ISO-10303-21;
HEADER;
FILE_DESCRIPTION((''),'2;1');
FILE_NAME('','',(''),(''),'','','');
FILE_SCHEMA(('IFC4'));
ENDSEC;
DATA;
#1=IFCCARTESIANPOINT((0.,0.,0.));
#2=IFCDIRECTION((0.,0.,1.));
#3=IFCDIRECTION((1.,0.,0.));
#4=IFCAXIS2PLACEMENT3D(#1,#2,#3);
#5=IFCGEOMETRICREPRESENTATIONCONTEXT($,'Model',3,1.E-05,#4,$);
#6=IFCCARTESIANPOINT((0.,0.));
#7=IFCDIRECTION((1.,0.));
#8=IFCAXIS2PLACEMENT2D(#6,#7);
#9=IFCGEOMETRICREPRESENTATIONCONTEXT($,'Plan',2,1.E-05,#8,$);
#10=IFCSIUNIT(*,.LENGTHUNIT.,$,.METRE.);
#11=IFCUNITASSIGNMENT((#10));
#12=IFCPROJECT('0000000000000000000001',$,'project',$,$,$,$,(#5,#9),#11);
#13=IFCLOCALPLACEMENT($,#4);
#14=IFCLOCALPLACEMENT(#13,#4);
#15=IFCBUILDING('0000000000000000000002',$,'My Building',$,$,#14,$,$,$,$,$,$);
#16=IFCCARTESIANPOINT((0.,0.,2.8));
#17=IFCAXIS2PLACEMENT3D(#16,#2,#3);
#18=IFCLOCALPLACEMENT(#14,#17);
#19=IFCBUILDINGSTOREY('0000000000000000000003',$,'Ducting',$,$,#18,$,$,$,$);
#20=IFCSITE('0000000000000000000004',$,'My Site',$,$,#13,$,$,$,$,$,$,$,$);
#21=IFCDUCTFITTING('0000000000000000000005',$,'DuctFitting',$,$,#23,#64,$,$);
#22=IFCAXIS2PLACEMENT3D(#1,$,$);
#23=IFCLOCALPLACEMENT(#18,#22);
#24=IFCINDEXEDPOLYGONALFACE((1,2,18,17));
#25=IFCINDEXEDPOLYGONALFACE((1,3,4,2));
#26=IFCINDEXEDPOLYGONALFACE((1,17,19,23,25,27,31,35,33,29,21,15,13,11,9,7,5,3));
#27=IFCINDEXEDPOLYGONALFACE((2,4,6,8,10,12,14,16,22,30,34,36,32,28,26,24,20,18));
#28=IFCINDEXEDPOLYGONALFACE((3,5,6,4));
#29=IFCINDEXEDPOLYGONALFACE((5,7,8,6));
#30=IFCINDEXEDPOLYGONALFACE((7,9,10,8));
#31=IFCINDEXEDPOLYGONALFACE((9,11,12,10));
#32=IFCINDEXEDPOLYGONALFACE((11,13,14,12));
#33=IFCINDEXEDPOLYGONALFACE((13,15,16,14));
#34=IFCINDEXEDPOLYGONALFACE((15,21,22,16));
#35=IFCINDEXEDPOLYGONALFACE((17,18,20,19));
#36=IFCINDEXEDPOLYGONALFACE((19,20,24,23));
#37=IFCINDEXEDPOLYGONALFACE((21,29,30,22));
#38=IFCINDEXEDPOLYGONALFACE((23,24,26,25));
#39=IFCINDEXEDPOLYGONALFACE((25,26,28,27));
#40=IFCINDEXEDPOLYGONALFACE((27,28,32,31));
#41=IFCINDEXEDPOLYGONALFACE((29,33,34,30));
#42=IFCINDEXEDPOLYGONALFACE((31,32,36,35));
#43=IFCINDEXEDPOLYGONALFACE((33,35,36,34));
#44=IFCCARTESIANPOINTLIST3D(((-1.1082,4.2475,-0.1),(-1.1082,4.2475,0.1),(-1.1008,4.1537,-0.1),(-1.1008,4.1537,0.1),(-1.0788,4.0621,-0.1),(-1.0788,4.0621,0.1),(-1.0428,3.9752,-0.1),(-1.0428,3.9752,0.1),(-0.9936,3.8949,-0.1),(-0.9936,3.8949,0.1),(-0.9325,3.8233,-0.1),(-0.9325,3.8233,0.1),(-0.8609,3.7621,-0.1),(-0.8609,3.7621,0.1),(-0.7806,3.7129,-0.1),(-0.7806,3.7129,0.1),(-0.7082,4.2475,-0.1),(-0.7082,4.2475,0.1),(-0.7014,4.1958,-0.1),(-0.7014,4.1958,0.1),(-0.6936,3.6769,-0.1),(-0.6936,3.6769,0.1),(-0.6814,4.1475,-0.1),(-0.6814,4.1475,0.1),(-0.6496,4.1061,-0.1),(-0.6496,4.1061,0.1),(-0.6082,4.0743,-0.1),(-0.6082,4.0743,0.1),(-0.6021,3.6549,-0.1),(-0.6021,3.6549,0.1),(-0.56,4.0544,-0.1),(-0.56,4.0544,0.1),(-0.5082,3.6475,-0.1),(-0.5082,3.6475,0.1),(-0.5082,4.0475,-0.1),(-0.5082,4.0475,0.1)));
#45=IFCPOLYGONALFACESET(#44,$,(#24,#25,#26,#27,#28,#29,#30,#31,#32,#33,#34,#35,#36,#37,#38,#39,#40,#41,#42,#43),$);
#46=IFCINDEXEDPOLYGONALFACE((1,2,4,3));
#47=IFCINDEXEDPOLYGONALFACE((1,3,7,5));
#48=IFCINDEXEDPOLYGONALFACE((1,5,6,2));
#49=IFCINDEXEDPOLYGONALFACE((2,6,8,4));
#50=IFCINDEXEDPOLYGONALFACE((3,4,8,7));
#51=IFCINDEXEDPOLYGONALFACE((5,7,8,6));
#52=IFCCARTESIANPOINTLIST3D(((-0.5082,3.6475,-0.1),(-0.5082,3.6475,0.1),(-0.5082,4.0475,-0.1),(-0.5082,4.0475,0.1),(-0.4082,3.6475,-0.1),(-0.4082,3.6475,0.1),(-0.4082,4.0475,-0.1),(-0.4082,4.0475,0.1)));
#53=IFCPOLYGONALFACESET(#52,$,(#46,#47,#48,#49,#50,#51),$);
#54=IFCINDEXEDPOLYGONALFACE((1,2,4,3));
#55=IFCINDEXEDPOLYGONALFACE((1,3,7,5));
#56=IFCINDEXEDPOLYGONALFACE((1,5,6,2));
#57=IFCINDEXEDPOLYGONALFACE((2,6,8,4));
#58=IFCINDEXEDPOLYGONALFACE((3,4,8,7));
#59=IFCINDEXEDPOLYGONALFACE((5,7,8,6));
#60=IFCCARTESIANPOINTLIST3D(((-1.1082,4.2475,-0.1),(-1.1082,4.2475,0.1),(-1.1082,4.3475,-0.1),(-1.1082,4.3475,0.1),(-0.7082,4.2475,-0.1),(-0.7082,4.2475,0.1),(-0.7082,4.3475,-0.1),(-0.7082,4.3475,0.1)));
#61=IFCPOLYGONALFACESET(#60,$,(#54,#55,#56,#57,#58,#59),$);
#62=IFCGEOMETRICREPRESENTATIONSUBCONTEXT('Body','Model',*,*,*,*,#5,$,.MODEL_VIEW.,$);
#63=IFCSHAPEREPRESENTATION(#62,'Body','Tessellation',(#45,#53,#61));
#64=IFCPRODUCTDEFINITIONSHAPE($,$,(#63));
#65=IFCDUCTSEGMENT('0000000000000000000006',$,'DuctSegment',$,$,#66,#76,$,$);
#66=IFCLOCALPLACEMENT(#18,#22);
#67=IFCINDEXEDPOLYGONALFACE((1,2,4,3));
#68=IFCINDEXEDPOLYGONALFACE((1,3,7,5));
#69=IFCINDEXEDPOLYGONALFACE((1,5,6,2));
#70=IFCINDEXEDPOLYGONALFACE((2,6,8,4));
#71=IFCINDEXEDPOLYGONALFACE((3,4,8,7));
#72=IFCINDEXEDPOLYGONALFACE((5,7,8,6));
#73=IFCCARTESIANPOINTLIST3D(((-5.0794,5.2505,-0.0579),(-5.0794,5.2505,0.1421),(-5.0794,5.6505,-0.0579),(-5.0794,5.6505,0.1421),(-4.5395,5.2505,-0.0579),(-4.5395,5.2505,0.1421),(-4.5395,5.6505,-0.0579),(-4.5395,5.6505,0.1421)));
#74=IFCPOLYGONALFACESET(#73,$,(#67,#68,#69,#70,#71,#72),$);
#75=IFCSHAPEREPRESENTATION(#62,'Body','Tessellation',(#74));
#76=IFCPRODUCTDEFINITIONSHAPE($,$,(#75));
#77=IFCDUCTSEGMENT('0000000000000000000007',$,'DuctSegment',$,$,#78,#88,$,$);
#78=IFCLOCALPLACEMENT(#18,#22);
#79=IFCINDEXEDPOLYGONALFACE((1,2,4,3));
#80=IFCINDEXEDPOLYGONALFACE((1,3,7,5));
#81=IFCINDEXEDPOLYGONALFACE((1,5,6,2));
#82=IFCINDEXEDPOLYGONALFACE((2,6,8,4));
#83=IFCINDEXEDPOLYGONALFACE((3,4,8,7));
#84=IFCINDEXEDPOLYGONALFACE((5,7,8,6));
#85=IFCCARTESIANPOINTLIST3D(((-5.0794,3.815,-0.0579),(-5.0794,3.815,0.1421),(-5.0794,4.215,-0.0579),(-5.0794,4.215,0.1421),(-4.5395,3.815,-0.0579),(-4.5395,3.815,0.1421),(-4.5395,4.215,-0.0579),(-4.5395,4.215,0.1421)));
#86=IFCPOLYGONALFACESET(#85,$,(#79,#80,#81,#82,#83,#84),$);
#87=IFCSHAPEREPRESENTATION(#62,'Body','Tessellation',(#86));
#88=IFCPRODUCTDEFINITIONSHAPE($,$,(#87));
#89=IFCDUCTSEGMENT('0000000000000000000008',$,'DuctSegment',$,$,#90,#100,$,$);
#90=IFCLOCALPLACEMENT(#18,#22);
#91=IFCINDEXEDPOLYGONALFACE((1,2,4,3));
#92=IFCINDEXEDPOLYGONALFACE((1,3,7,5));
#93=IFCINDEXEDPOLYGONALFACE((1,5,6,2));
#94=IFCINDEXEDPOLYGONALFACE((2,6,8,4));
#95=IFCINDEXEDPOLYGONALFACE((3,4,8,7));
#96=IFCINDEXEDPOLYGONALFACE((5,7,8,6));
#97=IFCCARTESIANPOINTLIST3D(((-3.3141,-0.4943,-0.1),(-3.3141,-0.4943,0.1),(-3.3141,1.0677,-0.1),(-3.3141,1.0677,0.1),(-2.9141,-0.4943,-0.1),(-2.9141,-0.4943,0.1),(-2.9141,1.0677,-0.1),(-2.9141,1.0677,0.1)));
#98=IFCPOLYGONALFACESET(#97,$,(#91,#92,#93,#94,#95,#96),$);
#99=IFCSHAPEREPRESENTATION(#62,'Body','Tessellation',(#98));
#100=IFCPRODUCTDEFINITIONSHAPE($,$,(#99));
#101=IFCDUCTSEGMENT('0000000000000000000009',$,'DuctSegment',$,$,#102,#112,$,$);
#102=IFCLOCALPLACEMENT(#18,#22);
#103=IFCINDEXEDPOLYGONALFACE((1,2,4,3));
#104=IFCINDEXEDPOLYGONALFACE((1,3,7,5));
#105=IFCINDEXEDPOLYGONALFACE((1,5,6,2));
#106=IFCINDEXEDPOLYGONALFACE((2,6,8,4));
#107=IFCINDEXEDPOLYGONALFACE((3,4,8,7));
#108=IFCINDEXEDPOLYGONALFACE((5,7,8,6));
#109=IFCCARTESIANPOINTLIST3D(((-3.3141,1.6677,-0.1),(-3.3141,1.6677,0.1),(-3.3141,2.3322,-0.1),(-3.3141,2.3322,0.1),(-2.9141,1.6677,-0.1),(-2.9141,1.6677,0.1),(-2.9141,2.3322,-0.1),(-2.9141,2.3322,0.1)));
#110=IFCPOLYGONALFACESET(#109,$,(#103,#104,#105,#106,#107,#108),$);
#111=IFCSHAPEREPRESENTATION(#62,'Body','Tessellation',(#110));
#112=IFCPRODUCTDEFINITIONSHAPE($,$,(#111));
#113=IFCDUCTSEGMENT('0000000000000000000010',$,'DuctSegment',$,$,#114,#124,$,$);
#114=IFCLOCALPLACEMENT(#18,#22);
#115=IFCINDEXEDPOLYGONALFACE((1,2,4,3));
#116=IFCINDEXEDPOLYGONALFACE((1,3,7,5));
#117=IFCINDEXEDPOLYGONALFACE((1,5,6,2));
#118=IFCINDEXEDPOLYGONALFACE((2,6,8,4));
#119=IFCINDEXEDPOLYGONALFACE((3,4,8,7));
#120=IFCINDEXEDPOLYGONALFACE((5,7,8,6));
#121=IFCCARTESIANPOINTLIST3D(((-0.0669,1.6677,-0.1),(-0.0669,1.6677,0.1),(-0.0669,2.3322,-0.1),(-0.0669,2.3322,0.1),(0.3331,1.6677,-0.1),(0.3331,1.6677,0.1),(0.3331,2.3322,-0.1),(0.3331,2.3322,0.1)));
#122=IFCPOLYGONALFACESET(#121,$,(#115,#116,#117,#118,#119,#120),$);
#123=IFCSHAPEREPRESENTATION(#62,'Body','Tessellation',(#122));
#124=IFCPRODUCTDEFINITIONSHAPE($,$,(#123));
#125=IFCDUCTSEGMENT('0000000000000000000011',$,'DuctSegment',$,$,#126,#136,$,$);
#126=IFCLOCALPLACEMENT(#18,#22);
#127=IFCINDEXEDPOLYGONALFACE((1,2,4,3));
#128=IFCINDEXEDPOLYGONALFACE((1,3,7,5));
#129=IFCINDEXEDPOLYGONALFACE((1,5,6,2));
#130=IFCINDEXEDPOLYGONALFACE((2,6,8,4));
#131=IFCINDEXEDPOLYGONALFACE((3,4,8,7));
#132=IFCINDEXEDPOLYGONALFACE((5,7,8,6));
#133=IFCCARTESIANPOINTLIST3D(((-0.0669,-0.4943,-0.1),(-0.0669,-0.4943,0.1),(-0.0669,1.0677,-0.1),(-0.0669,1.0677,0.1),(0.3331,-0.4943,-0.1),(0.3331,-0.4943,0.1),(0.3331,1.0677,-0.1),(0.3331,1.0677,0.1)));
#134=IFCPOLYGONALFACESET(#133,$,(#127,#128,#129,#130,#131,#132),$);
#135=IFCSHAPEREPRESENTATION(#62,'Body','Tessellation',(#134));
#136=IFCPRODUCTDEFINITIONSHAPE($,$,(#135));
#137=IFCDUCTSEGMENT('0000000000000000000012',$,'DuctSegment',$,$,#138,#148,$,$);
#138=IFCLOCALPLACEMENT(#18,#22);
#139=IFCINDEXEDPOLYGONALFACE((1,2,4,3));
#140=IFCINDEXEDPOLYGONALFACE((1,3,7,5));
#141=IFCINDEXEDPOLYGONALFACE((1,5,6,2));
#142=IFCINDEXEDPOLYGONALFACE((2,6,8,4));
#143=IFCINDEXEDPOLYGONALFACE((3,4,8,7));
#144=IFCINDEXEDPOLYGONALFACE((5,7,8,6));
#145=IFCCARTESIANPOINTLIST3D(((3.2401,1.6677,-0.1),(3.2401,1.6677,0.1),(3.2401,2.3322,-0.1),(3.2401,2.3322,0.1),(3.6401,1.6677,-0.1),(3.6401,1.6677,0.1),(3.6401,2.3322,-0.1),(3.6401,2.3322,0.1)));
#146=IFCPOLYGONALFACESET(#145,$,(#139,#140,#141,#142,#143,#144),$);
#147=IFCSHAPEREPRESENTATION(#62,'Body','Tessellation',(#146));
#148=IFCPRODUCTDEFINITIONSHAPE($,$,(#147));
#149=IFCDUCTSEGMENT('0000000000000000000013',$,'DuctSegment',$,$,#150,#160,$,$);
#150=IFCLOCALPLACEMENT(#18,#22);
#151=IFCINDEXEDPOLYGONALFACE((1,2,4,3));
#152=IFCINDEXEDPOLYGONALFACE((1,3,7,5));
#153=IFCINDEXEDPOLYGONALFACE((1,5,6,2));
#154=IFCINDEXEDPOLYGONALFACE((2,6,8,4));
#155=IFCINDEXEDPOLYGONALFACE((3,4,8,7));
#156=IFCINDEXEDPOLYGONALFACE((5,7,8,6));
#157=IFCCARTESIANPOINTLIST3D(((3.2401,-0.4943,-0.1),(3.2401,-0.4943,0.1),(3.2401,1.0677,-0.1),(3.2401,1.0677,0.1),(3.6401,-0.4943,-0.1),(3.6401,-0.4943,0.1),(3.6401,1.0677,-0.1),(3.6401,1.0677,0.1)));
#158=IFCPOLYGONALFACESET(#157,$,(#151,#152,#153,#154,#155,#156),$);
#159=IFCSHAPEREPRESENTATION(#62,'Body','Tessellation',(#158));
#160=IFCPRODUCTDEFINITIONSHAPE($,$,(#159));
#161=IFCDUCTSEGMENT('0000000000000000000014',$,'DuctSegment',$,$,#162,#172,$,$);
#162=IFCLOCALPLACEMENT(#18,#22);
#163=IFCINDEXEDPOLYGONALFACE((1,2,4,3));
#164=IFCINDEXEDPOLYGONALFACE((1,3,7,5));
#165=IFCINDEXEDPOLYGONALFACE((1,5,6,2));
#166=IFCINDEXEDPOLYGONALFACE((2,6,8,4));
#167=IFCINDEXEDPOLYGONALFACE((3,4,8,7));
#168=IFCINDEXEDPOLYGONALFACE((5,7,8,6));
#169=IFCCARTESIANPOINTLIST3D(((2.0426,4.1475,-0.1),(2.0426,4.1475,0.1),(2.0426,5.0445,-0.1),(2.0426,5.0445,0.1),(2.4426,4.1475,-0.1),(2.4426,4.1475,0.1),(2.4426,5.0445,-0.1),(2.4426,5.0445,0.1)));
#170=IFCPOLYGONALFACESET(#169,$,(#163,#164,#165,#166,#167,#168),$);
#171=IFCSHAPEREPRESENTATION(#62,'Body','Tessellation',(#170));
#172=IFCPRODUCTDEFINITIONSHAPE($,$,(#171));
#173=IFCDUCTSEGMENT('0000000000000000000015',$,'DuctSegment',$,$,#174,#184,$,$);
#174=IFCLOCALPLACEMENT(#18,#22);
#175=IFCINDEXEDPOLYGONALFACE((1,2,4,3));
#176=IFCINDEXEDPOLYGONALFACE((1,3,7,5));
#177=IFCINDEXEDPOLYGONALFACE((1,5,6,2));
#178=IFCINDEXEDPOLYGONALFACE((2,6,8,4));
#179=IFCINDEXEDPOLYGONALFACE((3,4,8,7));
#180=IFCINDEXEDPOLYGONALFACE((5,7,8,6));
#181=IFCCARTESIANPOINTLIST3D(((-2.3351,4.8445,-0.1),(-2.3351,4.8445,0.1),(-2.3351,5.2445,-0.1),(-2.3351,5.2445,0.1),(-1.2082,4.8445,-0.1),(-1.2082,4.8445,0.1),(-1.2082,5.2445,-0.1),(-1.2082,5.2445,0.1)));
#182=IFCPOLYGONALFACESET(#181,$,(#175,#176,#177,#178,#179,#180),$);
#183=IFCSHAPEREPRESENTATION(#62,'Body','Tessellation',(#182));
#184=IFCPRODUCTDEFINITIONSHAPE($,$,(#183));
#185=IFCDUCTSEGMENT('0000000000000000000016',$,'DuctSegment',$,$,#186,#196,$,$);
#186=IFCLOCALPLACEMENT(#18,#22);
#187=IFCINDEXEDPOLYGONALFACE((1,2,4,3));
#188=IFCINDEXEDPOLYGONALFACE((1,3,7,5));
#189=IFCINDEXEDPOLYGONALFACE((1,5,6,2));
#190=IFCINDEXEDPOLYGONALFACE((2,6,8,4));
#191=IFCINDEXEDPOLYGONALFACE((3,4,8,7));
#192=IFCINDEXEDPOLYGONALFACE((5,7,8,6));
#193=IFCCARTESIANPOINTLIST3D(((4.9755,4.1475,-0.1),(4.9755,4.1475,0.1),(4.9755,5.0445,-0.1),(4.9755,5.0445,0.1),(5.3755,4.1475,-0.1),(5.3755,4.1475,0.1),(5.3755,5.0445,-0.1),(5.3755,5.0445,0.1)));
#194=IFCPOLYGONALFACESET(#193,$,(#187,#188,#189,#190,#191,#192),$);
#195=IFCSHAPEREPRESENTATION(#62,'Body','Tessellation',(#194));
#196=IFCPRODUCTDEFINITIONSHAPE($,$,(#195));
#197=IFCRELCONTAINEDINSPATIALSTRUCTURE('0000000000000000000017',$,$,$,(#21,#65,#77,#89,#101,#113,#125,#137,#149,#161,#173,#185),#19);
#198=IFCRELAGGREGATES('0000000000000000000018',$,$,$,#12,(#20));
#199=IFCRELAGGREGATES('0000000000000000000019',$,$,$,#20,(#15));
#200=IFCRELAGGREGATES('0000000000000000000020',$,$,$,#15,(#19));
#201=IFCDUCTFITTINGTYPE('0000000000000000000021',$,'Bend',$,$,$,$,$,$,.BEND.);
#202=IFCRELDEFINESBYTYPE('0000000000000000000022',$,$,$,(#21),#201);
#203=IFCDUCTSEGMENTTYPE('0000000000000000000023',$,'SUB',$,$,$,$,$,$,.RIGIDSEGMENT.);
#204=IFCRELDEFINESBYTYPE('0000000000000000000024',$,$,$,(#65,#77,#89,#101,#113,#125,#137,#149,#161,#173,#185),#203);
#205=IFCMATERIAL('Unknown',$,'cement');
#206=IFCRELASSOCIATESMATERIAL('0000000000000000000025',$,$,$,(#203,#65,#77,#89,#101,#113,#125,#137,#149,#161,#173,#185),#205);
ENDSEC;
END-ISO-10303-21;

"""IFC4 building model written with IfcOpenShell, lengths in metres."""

from ifc_helpers import new_model, si_unit, frame, origin_with_axes, origin_2d_with_axis, place, context, subcontext, project, spatial, line, arc, indexed_curve, rectangle, outline, extrude, source, transform, mapped, material, material_profile, profile_set, profile_usage, type_object, type_shapes, element, save


model = new_model("IFC4")

# Units and contexts
model_context = context("Model", 3, precision=1e-05, world=origin_with_axes())
plan_context = context("Plan", 2, precision=1e-05, world=origin_2d_with_axis())
body_context = subcontext(model_context, "Body", "Model", "MODEL_VIEW")
ifc_project = project(units=[si_unit("LENGTHUNIT", "METRE")], contexts=[model_context, plan_context])

# Site, building, storey
site_placement = place(None, origin_with_axes())
site = spatial("IfcSite", under=ifc_project, at=site_placement, Name="My Site")
building_placement = place(site_placement, origin_with_axes())
building = spatial("IfcBuilding", under=site, at=building_placement, Name="My Building")
storey_placement = place(building_placement, frame((0.0, 0.0, 2.8), z_axis=(0.0, 0.0, 1.0), x_axis=(1.0, 0.0, 0.0)))
storey = spatial("IfcBuildingStorey", under=building, at=storey_placement, Name="Ducting")

# Shared definitions
ifc_material = material(Name="Unknown", Category="cement")

# Duct fitting
duct_fitting_type_1 = type_object("IfcDuctFittingType", Name="Bend", PredefinedType="BEND")
shared_shape = source(origin_with_axes(), body_context, "Body", "SweptSolid", [
    extrude(outline(indexed_curve([(0.2, 0.0), (0.2586, 0.1414), (0.4, 0.2), (0.4, 0.6), (-0.0243, 0.4243), (-0.2, 0.0)], segments=[arc(1, 2, 3), line(3, 4), arc(4, 5, 6), line(6, 1)])), frame((0.0, -0.1, 0.1), z_axis=(0.0, -1.0, 0.0), x_axis=(1.0, 0.0, 0.0)), (0.0, 0.0, -1.0), 0.2),
    extrude(rectangle(XDim=0.4, YDim=0.2), origin_with_axes(), (0.0, 0.0, 1.0), 0.1),
    extrude(rectangle(XDim=0.4, YDim=0.2), frame((0.4, 0.0, 0.5), z_axis=(1.0, 0.0, 0.000001), x_axis=(-0.000001, 0.0, 1.0)), (0.0, 0.0, 1.0), 0.1),
])
type_shapes(duct_fitting_type_1, [shared_shape])
for number, where, z_axis, x_axis, name in (
    (1, (-0.4082, 3.8475, 0.0), (-1.0, 0.0, 0.0), (0.0, 1.0, 0.0), "DuctFitting"),
):
    element("IfcDuctFitting", number, at=place(storey_placement, frame(where, z_axis=z_axis, x_axis=x_axis)), inside=storey, type_object=duct_fitting_type_1, Name=name, context=body_context, shape_type="MappedRepresentation", body=[
        mapped(shared_shape, transform((0.0, 0.0, 0.0), x_axis=(1.0, 0.0, 0.0), y_axis=(0.0, 1.0, 0.0), z_axis=(0.0, 0.0, 1.0), scale=1.0)),
    ])

# Duct segments
ifc_material_profile_1 = material_profile(ifc_material, rectangle(XDim=0.4, YDim=0.2))
ifc_profile_set_1 = profile_set([ifc_material_profile_1])
ifc_profile_usage_1 = profile_usage(ifc_profile_set_1, cardinal=5)
duct_segment_type_1 = type_object("IfcDuctSegmentType", Name="SUB", PredefinedType="RIGIDSEGMENT", material=ifc_profile_set_1)
duct_segment_1_placement = place(storey_placement, frame((-4.5395, 5.4505, 0.0421), z_axis=(-1.0, 0.0, 0.0), x_axis=(0.0, -1.0, 0.0)))
element("IfcDuctSegment", 2, at=duct_segment_1_placement, inside=storey, type_object=duct_segment_type_1, material=ifc_profile_usage_1, Name="DuctSegment", context=body_context, shape_type="SweptSolid", body=[
    extrude(rectangle(XDim=0.4, YDim=0.2), origin_with_axes(), (0.0, 0.0, 1.0), 0.5399),
])
ifc_profile_usage_2 = profile_usage(ifc_profile_set_1, cardinal=5)
duct_segment_2_placement = place(storey_placement, frame((-4.5395, 4.015, 0.0421), z_axis=(-1.0, 0.0, 0.0), x_axis=(0.0, -1.0, 0.0)))
element("IfcDuctSegment", 3, at=duct_segment_2_placement, inside=storey, type_object=duct_segment_type_1, material=ifc_profile_usage_2, Name="DuctSegment", context=body_context, shape_type="SweptSolid", body=[
    extrude(rectangle(XDim=0.4, YDim=0.2), origin_with_axes(), (0.0, 0.0, 1.0), 0.5399),
])
ifc_profile_usage_3 = profile_usage(ifc_profile_set_1, cardinal=5)
duct_segment_3_placement = place(storey_placement, frame((-3.1141, -0.4943, 0.0), z_axis=(0.0, 1.0, 0.0), x_axis=(-1.0, 0.0, 0.0)))
element("IfcDuctSegment", 4, at=duct_segment_3_placement, inside=storey, type_object=duct_segment_type_1, material=ifc_profile_usage_3, Name="DuctSegment", context=body_context, shape_type="SweptSolid", body=[
    extrude(rectangle(XDim=0.4, YDim=0.2), origin_with_axes(), (0.0, 0.0, 1.0), 1.5621),
])
ifc_profile_usage_4 = profile_usage(ifc_profile_set_1, cardinal=5)
duct_segment_4_placement = place(storey_placement, frame((-3.1141, 2.3322, 0.0), z_axis=(0.0, -1.0, 0.0), x_axis=(1.0, 0.0, 0.0)))
element("IfcDuctSegment", 5, at=duct_segment_4_placement, inside=storey, type_object=duct_segment_type_1, material=ifc_profile_usage_4, Name="DuctSegment", context=body_context, shape_type="SweptSolid", body=[
    extrude(rectangle(XDim=0.4, YDim=0.2), origin_with_axes(), (0.0, 0.0, 1.0), 0.6645),
])
ifc_profile_usage_5 = profile_usage(ifc_profile_set_1, cardinal=5)
duct_segment_5_placement = place(storey_placement, frame((0.1331, 2.3322, 0.0), z_axis=(0.0, -1.0, 0.0), x_axis=(1.0, 0.0, 0.0)))
element("IfcDuctSegment", 6, at=duct_segment_5_placement, inside=storey, type_object=duct_segment_type_1, material=ifc_profile_usage_5, Name="DuctSegment", context=body_context, shape_type="SweptSolid", body=[
    extrude(rectangle(XDim=0.4, YDim=0.2), origin_with_axes(), (0.0, 0.0, 1.0), 0.6645),
])
ifc_profile_usage_6 = profile_usage(ifc_profile_set_1, cardinal=5)
duct_segment_6_placement = place(storey_placement, frame((0.1331, -0.4943, 0.0), z_axis=(0.0, 1.0, 0.0), x_axis=(-1.0, 0.0, 0.0)))
element("IfcDuctSegment", 7, at=duct_segment_6_placement, inside=storey, type_object=duct_segment_type_1, material=ifc_profile_usage_6, Name="DuctSegment", context=body_context, shape_type="SweptSolid", body=[
    extrude(rectangle(XDim=0.4, YDim=0.2), origin_with_axes(), (0.0, 0.0, 1.0), 1.5621),
])
ifc_profile_usage_7 = profile_usage(ifc_profile_set_1, cardinal=5)
duct_segment_7_placement = place(storey_placement, frame((3.4401, 2.3322, 0.0), z_axis=(0.0, -1.0, 0.0), x_axis=(1.0, 0.0, 0.0)))
element("IfcDuctSegment", 8, at=duct_segment_7_placement, inside=storey, type_object=duct_segment_type_1, material=ifc_profile_usage_7, Name="DuctSegment", context=body_context, shape_type="SweptSolid", body=[
    extrude(rectangle(XDim=0.4, YDim=0.2), origin_with_axes(), (0.0, 0.0, 1.0), 0.6645),
])
ifc_profile_usage_8 = profile_usage(ifc_profile_set_1, cardinal=5)
duct_segment_8_placement = place(storey_placement, frame((3.4401, -0.4943, 0.0), z_axis=(0.0, 1.0, 0.0), x_axis=(-1.0, 0.0, 0.0)))
element("IfcDuctSegment", 9, at=duct_segment_8_placement, inside=storey, type_object=duct_segment_type_1, material=ifc_profile_usage_8, Name="DuctSegment", context=body_context, shape_type="SweptSolid", body=[
    extrude(rectangle(XDim=0.4, YDim=0.2), origin_with_axes(), (0.0, 0.0, 1.0), 1.5621),
])
ifc_profile_usage_9 = profile_usage(ifc_profile_set_1, cardinal=5)
duct_segment_9_placement = place(storey_placement, frame((2.2426, 5.0445, 0.0), z_axis=(0.0, -1.0, 0.0), x_axis=(1.0, 0.0, 0.0)))
element("IfcDuctSegment", 10, at=duct_segment_9_placement, inside=storey, type_object=duct_segment_type_1, material=ifc_profile_usage_9, Name="DuctSegment", context=body_context, shape_type="SweptSolid", body=[
    extrude(rectangle(XDim=0.4, YDim=0.2), origin_with_axes(), (0.0, 0.0, 1.0), 0.897),
])
ifc_profile_usage_10 = profile_usage(ifc_profile_set_1, cardinal=5)
duct_segment_10_placement = place(storey_placement, frame((-2.3351, 5.0445, 0.0), z_axis=(1.0, 0.0, 0.0), x_axis=(0.0, 1.0, 0.0)))
element("IfcDuctSegment", 11, at=duct_segment_10_placement, inside=storey, type_object=duct_segment_type_1, material=ifc_profile_usage_10, Name="DuctSegment", context=body_context, shape_type="SweptSolid", body=[
    extrude(rectangle(XDim=0.4, YDim=0.2), origin_with_axes(), (0.0, 0.0, 1.0), 1.1269),
])
ifc_profile_usage_11 = profile_usage(ifc_profile_set_1, cardinal=5)
duct_segment_11_placement = place(storey_placement, frame((5.1755, 5.0445, 0.0), z_axis=(0.0, -1.0, 0.0), x_axis=(1.0, 0.0, 0.0)))
element("IfcDuctSegment", 12, at=duct_segment_11_placement, inside=storey, type_object=duct_segment_type_1, material=ifc_profile_usage_11, Name="DuctSegment", context=body_context, shape_type="SweptSolid", body=[
    extrude(rectangle(XDim=0.4, YDim=0.2), origin_with_axes(), (0.0, 0.0, 1.0), 0.897),
])

save(model, "model.ifc")
